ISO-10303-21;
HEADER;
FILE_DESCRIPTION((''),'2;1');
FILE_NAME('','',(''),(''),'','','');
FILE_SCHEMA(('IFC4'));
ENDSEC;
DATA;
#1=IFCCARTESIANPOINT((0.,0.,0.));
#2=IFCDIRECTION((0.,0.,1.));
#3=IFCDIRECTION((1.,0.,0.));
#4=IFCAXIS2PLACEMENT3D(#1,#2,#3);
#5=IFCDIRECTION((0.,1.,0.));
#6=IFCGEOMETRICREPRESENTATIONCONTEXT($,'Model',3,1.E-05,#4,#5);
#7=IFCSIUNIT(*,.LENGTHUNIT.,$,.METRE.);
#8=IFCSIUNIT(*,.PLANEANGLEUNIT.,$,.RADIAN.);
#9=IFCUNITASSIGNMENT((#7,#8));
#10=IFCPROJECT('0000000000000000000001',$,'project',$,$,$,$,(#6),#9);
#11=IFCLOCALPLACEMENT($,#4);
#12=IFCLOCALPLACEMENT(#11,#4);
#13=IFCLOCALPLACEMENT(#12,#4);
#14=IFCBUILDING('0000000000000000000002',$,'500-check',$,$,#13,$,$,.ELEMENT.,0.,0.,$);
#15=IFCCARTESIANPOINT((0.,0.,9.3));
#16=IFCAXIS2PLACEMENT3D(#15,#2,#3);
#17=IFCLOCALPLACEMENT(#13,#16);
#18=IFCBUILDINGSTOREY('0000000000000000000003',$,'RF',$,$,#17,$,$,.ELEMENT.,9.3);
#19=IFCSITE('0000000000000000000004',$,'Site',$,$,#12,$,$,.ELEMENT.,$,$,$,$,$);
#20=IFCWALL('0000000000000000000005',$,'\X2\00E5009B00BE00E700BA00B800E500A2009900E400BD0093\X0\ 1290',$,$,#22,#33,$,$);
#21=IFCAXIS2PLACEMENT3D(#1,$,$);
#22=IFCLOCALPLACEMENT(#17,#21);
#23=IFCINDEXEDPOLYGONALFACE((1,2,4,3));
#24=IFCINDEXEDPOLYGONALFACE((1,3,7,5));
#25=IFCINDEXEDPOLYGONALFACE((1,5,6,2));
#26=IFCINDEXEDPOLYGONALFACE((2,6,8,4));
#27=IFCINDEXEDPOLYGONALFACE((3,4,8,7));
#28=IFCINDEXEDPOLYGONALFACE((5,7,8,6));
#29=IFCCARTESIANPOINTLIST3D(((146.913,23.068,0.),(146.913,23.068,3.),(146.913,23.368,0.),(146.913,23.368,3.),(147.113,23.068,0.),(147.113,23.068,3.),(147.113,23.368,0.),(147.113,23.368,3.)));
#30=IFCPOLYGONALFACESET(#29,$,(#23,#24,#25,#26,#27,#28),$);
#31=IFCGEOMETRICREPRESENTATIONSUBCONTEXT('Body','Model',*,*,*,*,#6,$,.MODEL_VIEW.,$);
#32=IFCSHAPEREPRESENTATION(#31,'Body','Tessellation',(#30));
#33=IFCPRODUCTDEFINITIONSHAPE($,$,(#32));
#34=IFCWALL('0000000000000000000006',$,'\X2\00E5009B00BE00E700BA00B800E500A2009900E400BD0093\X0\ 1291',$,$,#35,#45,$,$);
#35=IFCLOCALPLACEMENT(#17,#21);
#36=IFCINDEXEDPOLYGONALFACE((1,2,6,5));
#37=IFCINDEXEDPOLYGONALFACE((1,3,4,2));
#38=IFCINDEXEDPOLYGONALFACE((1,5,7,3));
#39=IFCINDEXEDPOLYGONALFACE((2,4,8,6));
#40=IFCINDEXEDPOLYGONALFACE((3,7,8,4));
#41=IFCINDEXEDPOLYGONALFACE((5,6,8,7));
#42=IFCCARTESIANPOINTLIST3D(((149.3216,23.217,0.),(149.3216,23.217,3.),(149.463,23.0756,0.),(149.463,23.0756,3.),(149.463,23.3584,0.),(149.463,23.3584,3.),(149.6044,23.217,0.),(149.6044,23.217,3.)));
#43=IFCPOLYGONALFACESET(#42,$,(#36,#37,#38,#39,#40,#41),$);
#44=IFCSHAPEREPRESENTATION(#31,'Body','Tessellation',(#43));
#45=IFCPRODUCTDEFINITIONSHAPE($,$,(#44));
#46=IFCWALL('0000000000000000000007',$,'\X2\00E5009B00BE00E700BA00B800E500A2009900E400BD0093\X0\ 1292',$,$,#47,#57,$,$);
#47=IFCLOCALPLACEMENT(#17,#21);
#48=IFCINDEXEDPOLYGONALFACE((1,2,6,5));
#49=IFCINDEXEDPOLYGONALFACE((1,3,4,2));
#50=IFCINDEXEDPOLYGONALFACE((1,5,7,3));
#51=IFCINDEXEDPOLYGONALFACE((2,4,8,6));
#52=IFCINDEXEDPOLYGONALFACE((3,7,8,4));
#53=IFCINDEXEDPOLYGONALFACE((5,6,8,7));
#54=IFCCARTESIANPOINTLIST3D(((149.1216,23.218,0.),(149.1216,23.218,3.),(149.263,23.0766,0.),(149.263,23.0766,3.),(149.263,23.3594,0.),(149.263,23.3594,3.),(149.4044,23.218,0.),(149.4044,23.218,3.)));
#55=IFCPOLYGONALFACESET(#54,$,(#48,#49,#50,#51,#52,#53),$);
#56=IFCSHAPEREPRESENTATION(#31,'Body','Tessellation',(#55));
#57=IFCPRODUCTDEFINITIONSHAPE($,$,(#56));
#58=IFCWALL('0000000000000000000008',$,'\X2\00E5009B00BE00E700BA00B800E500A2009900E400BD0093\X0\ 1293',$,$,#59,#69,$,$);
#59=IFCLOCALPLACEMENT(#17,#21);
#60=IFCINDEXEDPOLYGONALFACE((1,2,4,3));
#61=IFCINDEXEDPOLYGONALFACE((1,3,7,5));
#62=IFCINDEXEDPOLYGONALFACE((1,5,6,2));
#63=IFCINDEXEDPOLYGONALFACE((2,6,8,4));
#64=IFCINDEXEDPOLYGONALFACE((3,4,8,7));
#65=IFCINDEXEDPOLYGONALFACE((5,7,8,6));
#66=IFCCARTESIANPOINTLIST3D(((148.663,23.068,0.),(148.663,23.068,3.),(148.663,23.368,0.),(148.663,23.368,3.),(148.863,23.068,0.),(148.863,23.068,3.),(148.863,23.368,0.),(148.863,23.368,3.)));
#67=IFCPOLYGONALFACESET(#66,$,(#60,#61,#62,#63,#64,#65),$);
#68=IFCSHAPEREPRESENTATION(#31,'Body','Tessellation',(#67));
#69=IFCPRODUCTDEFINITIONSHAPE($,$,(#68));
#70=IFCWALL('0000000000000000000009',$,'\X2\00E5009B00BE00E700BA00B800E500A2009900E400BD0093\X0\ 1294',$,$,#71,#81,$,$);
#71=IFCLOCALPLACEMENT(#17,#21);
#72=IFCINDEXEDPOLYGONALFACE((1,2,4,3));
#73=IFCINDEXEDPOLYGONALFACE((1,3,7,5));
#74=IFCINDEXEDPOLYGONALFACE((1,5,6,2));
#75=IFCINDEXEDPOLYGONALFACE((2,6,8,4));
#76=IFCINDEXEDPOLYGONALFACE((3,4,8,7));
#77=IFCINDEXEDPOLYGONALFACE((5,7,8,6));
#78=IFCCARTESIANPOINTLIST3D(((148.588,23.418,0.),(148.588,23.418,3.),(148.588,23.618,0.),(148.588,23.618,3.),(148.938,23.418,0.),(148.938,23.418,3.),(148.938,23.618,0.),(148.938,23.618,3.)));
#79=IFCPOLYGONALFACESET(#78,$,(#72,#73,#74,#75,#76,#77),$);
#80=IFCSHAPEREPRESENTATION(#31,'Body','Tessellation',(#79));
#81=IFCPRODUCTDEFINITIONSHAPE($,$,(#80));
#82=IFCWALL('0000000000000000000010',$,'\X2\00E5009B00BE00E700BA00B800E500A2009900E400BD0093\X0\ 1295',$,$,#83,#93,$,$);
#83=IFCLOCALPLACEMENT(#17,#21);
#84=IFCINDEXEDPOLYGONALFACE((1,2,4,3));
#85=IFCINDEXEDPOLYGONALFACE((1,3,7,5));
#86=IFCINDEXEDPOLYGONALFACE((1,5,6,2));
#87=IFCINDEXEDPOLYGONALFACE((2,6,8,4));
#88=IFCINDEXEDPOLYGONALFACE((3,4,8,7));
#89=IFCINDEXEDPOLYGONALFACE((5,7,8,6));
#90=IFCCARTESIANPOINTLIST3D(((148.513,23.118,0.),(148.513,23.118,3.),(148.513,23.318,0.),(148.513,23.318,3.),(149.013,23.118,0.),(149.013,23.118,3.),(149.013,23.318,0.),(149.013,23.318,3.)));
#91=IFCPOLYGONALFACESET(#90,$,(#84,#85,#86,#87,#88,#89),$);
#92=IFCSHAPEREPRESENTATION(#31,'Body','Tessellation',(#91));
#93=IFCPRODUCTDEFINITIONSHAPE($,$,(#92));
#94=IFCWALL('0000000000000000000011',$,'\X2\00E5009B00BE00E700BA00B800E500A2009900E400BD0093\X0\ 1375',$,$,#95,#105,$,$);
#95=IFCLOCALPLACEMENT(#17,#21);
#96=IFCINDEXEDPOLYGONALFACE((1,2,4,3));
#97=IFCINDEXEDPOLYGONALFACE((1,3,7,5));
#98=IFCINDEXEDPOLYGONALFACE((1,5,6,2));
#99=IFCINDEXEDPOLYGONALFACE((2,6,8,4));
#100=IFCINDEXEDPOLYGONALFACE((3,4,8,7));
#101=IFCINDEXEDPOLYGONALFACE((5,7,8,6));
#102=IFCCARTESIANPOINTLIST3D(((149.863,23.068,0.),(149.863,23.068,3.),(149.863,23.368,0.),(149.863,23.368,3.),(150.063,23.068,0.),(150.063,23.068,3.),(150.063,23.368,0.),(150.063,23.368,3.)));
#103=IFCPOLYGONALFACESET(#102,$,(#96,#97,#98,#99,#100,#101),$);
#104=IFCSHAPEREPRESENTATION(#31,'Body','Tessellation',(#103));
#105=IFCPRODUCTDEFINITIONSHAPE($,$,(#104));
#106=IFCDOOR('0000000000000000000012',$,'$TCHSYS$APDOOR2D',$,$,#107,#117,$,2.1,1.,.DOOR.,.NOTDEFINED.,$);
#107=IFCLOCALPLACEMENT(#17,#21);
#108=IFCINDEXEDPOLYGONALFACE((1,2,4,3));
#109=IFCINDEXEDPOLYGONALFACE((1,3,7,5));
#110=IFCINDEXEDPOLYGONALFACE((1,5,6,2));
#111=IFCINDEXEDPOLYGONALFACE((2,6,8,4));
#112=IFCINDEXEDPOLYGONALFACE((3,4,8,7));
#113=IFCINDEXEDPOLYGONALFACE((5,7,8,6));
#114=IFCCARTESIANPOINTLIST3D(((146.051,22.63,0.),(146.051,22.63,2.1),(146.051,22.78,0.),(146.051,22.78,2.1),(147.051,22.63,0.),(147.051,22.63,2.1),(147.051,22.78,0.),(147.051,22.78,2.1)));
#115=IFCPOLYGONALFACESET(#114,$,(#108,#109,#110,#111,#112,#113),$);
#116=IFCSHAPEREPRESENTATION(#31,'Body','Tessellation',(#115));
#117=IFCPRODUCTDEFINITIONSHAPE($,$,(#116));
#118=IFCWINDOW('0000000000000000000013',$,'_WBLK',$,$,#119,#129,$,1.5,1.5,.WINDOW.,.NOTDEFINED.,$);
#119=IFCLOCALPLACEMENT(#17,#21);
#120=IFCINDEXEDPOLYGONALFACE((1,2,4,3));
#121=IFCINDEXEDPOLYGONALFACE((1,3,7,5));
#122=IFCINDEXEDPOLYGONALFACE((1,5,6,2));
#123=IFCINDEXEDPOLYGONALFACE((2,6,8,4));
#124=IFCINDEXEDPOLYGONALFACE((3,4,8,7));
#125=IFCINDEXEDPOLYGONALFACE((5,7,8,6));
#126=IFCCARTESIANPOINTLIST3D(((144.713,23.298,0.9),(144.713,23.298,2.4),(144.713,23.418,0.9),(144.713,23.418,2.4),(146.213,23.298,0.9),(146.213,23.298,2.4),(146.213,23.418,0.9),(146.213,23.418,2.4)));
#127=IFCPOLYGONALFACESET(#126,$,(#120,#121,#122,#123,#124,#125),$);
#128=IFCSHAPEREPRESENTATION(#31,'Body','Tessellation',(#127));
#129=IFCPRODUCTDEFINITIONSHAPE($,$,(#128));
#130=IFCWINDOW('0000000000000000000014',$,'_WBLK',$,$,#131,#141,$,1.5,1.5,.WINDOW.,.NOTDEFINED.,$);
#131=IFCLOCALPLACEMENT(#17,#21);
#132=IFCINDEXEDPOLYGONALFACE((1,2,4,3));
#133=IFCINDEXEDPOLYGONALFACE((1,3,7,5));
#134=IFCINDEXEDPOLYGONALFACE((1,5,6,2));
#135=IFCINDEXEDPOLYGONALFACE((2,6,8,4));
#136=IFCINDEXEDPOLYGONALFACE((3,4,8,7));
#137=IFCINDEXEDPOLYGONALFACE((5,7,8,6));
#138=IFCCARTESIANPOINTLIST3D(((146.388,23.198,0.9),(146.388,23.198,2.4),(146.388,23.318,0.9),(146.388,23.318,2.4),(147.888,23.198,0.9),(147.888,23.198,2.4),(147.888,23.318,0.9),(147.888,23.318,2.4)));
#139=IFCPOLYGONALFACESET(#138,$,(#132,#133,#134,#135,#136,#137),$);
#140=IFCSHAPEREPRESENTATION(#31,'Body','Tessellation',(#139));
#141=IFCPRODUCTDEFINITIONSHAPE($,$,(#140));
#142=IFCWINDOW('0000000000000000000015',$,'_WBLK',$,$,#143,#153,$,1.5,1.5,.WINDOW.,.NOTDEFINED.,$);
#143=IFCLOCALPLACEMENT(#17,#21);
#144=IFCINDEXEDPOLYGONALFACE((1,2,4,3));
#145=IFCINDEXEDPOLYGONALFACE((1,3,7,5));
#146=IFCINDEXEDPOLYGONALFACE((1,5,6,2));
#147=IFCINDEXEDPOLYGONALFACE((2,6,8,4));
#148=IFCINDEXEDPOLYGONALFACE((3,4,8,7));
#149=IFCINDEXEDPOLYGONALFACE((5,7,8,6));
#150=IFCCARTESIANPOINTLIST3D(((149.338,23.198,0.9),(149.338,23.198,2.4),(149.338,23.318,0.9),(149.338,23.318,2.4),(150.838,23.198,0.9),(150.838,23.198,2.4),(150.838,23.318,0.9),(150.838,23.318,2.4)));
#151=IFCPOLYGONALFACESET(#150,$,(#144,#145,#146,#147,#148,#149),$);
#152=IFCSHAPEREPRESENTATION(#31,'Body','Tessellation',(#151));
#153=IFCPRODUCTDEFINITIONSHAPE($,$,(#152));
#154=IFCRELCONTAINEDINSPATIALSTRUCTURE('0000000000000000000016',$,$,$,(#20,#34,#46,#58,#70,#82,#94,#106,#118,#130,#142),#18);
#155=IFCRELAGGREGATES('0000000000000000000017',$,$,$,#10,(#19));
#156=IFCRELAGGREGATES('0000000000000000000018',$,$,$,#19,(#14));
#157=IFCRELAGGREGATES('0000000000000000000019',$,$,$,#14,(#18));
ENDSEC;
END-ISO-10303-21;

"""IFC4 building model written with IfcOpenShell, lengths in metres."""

from ifc_helpers import new_model, si_unit, direction, frame, frame_2d, origin_with_axes, place, context, subcontext, project, spatial, rectangle, extrude, element, save


model = new_model("IFC4")

# Units and contexts
model_context = context("Model", 3, precision=1e-05, world=origin_with_axes(), true_north=direction((0.0, 1.0, 0.0)))
body_context = subcontext(model_context, "Body", "Model", "MODEL_VIEW")
ifc_project = project(units=[si_unit("LENGTHUNIT", "METRE"), si_unit("PLANEANGLEUNIT", "RADIAN")], contexts=[model_context])

# Site, building, storey
placement = place(None, origin_with_axes())
site_placement = place(placement, origin_with_axes())
site = spatial("IfcSite", under=ifc_project, at=site_placement, Name="Site", CompositionType="ELEMENT")
building_placement = place(site_placement, origin_with_axes())
building = spatial("IfcBuilding", under=site, at=building_placement, Name="500-check", CompositionType="ELEMENT", ElevationOfRefHeight=0.0, ElevationOfTerrain=0.0)
storey_placement = place(building_placement, frame((0.0, 0.0, 9.3), z_axis=(0.0, 0.0, 1.0), x_axis=(1.0, 0.0, 0.0)))
storey = spatial("IfcBuildingStorey", under=building, at=storey_placement, Name="RF", CompositionType="ELEMENT", Elevation=9.3)

# Walls
wall_1_placement = place(storey_placement, frame((147.013, 23.218, 0.0), z_axis=(0.0, 0.0, 1.0), x_axis=(0.0, 1.0, 0.0)))
element("IfcWall", 1, at=wall_1_placement, inside=storey, Name="å\u009b¾çº¸å¢\u0099ä½\u0093 1290", context=body_context, shape_type="SweptSolid", body=[
    extrude(rectangle(XDim=0.3, YDim=0.2, at=frame_2d((0.0, 0.0), x_axis=(1.0, 0.0, 0.0))), frame((0.0, 0.0, 0.0), z_axis=(0.0, 0.0, 1.0)), (0.0, 0.0, 1.0), 3.0),
])
for number, where, z_axis, x_axis, name in (
    (2, (149.463, 23.217, 0.0), (0.0, 0.0, 1.0), (0.707107, 0.707107, 0.0), "å\u009b¾çº¸å¢\u0099ä½\u0093 1291"),
    (3, (149.263, 23.218, 0.0), (0.0, 0.0, 1.0), (0.707107, -0.707107, 0.0), "å\u009b¾çº¸å¢\u0099ä½\u0093 1292"),
):
    element("IfcWall", number, at=place(storey_placement, frame(where, z_axis=z_axis, x_axis=x_axis)), inside=storey, Name=name, context=body_context, shape_type="SweptSolid", body=[
        extrude(rectangle(XDim=0.2, YDim=0.2, at=frame_2d((0.0, 0.0), x_axis=(1.0, 0.0, 0.0))), frame((0.0, 0.0, 0.0), z_axis=(0.0, 0.0, 1.0)), (0.0, 0.0, 1.0), 3.0),
    ])
wall_2_placement = place(storey_placement, frame((148.763, 23.218, 0.0), z_axis=(0.0, 0.0, 1.0), x_axis=(0.0, 1.0, 0.0)))
element("IfcWall", 4, at=wall_2_placement, inside=storey, Name="å\u009b¾çº¸å¢\u0099ä½\u0093 1293", context=body_context, shape_type="SweptSolid", body=[
    extrude(rectangle(XDim=0.3, YDim=0.2, at=frame_2d((0.0, 0.0), x_axis=(1.0, 0.0, 0.0))), frame((0.0, 0.0, 0.0), z_axis=(0.0, 0.0, 1.0)), (0.0, 0.0, 1.0), 3.0),
])
wall_3_placement = place(storey_placement, frame((148.763, 23.518, 0.0), z_axis=(0.0, 0.0, 1.0), x_axis=(1.0, 0.0, 0.0)))
element("IfcWall", 5, at=wall_3_placement, inside=storey, Name="å\u009b¾çº¸å¢\u0099ä½\u0093 1294", context=body_context, shape_type="SweptSolid", body=[
    extrude(rectangle(XDim=0.35, YDim=0.2, at=frame_2d((0.0, 0.0), x_axis=(1.0, 0.0, 0.0))), frame((0.0, 0.0, 0.0), z_axis=(0.0, 0.0, 1.0)), (0.0, 0.0, 1.0), 3.0),
])
wall_4_placement = place(storey_placement, frame((148.763, 23.218, 0.0), z_axis=(0.0, 0.0, 1.0), x_axis=(1.0, 0.0, 0.0)))
element("IfcWall", 6, at=wall_4_placement, inside=storey, Name="å\u009b¾çº¸å¢\u0099ä½\u0093 1295", context=body_context, shape_type="SweptSolid", body=[
    extrude(rectangle(XDim=0.5, YDim=0.2, at=frame_2d((0.0, 0.0), x_axis=(1.0, 0.0, 0.0))), frame((0.0, 0.0, 0.0), z_axis=(0.0, 0.0, 1.0)), (0.0, 0.0, 1.0), 3.0),
])
wall_5_placement = place(storey_placement, frame((149.963, 23.218, 0.0), z_axis=(0.0, 0.0, 1.0), x_axis=(0.0, 1.0, 0.0)))
element("IfcWall", 7, at=wall_5_placement, inside=storey, Name="å\u009b¾çº¸å¢\u0099ä½\u0093 1375", context=body_context, shape_type="SweptSolid", body=[
    extrude(rectangle(XDim=0.3, YDim=0.2, at=frame_2d((0.0, 0.0), x_axis=(1.0, 0.0, 0.0))), frame((0.0, 0.0, 0.0), z_axis=(0.0, 0.0, 1.0)), (0.0, 0.0, 1.0), 3.0),
])

# Door
door_placement = place(storey_placement, frame((146.551, 22.705, 0.0), z_axis=(0.0, 0.0, 1.0), x_axis=(1.0, 0.0, 0.0)))
element("IfcDoor", 8, at=door_placement, inside=storey, Name="$TCHSYS$APDOOR2D", OperationType="NOTDEFINED", OverallHeight=2.1, OverallWidth=1.0, PredefinedType="DOOR", context=body_context, shape_type="SweptSolid", body=[
    extrude(rectangle(XDim=1.0, YDim=0.15, at=frame_2d((0.0, 0.0), x_axis=(1.0, 0.0, 0.0))), frame((0.0, 0.0, 0.0), z_axis=(0.0, 0.0, 1.0)), (0.0, 0.0, 1.0), 2.1),
])

# Windows
for number, where, z_axis, x_axis, name in (
    (9, (145.463, 23.358, 0.9), (0.0, 0.0, 1.0), (1.0, 0.0, 0.0), "_WBLK"),
    (10, (147.138, 23.258, 0.9), (0.0, 0.0, 1.0), (1.0, 0.0, 0.0), "_WBLK"),
    (11, (150.088, 23.258, 0.9), (0.0, 0.0, 1.0), (1.0, 0.0, 0.0), "_WBLK"),
):
    element("IfcWindow", number, at=place(storey_placement, frame(where, z_axis=z_axis, x_axis=x_axis)), inside=storey, Name=name, OverallHeight=1.5, OverallWidth=1.5, PartitioningType="NOTDEFINED", PredefinedType="WINDOW", context=body_context, shape_type="SweptSolid", body=[
        extrude(rectangle(XDim=1.5, YDim=0.12, at=frame_2d((0.0, 0.0), x_axis=(1.0, 0.0, 0.0))), frame((0.0, 0.0, 0.0), z_axis=(0.0, 0.0, 1.0)), (0.0, 0.0, 1.0), 1.5),
    ])

save(model, "model.ifc")
